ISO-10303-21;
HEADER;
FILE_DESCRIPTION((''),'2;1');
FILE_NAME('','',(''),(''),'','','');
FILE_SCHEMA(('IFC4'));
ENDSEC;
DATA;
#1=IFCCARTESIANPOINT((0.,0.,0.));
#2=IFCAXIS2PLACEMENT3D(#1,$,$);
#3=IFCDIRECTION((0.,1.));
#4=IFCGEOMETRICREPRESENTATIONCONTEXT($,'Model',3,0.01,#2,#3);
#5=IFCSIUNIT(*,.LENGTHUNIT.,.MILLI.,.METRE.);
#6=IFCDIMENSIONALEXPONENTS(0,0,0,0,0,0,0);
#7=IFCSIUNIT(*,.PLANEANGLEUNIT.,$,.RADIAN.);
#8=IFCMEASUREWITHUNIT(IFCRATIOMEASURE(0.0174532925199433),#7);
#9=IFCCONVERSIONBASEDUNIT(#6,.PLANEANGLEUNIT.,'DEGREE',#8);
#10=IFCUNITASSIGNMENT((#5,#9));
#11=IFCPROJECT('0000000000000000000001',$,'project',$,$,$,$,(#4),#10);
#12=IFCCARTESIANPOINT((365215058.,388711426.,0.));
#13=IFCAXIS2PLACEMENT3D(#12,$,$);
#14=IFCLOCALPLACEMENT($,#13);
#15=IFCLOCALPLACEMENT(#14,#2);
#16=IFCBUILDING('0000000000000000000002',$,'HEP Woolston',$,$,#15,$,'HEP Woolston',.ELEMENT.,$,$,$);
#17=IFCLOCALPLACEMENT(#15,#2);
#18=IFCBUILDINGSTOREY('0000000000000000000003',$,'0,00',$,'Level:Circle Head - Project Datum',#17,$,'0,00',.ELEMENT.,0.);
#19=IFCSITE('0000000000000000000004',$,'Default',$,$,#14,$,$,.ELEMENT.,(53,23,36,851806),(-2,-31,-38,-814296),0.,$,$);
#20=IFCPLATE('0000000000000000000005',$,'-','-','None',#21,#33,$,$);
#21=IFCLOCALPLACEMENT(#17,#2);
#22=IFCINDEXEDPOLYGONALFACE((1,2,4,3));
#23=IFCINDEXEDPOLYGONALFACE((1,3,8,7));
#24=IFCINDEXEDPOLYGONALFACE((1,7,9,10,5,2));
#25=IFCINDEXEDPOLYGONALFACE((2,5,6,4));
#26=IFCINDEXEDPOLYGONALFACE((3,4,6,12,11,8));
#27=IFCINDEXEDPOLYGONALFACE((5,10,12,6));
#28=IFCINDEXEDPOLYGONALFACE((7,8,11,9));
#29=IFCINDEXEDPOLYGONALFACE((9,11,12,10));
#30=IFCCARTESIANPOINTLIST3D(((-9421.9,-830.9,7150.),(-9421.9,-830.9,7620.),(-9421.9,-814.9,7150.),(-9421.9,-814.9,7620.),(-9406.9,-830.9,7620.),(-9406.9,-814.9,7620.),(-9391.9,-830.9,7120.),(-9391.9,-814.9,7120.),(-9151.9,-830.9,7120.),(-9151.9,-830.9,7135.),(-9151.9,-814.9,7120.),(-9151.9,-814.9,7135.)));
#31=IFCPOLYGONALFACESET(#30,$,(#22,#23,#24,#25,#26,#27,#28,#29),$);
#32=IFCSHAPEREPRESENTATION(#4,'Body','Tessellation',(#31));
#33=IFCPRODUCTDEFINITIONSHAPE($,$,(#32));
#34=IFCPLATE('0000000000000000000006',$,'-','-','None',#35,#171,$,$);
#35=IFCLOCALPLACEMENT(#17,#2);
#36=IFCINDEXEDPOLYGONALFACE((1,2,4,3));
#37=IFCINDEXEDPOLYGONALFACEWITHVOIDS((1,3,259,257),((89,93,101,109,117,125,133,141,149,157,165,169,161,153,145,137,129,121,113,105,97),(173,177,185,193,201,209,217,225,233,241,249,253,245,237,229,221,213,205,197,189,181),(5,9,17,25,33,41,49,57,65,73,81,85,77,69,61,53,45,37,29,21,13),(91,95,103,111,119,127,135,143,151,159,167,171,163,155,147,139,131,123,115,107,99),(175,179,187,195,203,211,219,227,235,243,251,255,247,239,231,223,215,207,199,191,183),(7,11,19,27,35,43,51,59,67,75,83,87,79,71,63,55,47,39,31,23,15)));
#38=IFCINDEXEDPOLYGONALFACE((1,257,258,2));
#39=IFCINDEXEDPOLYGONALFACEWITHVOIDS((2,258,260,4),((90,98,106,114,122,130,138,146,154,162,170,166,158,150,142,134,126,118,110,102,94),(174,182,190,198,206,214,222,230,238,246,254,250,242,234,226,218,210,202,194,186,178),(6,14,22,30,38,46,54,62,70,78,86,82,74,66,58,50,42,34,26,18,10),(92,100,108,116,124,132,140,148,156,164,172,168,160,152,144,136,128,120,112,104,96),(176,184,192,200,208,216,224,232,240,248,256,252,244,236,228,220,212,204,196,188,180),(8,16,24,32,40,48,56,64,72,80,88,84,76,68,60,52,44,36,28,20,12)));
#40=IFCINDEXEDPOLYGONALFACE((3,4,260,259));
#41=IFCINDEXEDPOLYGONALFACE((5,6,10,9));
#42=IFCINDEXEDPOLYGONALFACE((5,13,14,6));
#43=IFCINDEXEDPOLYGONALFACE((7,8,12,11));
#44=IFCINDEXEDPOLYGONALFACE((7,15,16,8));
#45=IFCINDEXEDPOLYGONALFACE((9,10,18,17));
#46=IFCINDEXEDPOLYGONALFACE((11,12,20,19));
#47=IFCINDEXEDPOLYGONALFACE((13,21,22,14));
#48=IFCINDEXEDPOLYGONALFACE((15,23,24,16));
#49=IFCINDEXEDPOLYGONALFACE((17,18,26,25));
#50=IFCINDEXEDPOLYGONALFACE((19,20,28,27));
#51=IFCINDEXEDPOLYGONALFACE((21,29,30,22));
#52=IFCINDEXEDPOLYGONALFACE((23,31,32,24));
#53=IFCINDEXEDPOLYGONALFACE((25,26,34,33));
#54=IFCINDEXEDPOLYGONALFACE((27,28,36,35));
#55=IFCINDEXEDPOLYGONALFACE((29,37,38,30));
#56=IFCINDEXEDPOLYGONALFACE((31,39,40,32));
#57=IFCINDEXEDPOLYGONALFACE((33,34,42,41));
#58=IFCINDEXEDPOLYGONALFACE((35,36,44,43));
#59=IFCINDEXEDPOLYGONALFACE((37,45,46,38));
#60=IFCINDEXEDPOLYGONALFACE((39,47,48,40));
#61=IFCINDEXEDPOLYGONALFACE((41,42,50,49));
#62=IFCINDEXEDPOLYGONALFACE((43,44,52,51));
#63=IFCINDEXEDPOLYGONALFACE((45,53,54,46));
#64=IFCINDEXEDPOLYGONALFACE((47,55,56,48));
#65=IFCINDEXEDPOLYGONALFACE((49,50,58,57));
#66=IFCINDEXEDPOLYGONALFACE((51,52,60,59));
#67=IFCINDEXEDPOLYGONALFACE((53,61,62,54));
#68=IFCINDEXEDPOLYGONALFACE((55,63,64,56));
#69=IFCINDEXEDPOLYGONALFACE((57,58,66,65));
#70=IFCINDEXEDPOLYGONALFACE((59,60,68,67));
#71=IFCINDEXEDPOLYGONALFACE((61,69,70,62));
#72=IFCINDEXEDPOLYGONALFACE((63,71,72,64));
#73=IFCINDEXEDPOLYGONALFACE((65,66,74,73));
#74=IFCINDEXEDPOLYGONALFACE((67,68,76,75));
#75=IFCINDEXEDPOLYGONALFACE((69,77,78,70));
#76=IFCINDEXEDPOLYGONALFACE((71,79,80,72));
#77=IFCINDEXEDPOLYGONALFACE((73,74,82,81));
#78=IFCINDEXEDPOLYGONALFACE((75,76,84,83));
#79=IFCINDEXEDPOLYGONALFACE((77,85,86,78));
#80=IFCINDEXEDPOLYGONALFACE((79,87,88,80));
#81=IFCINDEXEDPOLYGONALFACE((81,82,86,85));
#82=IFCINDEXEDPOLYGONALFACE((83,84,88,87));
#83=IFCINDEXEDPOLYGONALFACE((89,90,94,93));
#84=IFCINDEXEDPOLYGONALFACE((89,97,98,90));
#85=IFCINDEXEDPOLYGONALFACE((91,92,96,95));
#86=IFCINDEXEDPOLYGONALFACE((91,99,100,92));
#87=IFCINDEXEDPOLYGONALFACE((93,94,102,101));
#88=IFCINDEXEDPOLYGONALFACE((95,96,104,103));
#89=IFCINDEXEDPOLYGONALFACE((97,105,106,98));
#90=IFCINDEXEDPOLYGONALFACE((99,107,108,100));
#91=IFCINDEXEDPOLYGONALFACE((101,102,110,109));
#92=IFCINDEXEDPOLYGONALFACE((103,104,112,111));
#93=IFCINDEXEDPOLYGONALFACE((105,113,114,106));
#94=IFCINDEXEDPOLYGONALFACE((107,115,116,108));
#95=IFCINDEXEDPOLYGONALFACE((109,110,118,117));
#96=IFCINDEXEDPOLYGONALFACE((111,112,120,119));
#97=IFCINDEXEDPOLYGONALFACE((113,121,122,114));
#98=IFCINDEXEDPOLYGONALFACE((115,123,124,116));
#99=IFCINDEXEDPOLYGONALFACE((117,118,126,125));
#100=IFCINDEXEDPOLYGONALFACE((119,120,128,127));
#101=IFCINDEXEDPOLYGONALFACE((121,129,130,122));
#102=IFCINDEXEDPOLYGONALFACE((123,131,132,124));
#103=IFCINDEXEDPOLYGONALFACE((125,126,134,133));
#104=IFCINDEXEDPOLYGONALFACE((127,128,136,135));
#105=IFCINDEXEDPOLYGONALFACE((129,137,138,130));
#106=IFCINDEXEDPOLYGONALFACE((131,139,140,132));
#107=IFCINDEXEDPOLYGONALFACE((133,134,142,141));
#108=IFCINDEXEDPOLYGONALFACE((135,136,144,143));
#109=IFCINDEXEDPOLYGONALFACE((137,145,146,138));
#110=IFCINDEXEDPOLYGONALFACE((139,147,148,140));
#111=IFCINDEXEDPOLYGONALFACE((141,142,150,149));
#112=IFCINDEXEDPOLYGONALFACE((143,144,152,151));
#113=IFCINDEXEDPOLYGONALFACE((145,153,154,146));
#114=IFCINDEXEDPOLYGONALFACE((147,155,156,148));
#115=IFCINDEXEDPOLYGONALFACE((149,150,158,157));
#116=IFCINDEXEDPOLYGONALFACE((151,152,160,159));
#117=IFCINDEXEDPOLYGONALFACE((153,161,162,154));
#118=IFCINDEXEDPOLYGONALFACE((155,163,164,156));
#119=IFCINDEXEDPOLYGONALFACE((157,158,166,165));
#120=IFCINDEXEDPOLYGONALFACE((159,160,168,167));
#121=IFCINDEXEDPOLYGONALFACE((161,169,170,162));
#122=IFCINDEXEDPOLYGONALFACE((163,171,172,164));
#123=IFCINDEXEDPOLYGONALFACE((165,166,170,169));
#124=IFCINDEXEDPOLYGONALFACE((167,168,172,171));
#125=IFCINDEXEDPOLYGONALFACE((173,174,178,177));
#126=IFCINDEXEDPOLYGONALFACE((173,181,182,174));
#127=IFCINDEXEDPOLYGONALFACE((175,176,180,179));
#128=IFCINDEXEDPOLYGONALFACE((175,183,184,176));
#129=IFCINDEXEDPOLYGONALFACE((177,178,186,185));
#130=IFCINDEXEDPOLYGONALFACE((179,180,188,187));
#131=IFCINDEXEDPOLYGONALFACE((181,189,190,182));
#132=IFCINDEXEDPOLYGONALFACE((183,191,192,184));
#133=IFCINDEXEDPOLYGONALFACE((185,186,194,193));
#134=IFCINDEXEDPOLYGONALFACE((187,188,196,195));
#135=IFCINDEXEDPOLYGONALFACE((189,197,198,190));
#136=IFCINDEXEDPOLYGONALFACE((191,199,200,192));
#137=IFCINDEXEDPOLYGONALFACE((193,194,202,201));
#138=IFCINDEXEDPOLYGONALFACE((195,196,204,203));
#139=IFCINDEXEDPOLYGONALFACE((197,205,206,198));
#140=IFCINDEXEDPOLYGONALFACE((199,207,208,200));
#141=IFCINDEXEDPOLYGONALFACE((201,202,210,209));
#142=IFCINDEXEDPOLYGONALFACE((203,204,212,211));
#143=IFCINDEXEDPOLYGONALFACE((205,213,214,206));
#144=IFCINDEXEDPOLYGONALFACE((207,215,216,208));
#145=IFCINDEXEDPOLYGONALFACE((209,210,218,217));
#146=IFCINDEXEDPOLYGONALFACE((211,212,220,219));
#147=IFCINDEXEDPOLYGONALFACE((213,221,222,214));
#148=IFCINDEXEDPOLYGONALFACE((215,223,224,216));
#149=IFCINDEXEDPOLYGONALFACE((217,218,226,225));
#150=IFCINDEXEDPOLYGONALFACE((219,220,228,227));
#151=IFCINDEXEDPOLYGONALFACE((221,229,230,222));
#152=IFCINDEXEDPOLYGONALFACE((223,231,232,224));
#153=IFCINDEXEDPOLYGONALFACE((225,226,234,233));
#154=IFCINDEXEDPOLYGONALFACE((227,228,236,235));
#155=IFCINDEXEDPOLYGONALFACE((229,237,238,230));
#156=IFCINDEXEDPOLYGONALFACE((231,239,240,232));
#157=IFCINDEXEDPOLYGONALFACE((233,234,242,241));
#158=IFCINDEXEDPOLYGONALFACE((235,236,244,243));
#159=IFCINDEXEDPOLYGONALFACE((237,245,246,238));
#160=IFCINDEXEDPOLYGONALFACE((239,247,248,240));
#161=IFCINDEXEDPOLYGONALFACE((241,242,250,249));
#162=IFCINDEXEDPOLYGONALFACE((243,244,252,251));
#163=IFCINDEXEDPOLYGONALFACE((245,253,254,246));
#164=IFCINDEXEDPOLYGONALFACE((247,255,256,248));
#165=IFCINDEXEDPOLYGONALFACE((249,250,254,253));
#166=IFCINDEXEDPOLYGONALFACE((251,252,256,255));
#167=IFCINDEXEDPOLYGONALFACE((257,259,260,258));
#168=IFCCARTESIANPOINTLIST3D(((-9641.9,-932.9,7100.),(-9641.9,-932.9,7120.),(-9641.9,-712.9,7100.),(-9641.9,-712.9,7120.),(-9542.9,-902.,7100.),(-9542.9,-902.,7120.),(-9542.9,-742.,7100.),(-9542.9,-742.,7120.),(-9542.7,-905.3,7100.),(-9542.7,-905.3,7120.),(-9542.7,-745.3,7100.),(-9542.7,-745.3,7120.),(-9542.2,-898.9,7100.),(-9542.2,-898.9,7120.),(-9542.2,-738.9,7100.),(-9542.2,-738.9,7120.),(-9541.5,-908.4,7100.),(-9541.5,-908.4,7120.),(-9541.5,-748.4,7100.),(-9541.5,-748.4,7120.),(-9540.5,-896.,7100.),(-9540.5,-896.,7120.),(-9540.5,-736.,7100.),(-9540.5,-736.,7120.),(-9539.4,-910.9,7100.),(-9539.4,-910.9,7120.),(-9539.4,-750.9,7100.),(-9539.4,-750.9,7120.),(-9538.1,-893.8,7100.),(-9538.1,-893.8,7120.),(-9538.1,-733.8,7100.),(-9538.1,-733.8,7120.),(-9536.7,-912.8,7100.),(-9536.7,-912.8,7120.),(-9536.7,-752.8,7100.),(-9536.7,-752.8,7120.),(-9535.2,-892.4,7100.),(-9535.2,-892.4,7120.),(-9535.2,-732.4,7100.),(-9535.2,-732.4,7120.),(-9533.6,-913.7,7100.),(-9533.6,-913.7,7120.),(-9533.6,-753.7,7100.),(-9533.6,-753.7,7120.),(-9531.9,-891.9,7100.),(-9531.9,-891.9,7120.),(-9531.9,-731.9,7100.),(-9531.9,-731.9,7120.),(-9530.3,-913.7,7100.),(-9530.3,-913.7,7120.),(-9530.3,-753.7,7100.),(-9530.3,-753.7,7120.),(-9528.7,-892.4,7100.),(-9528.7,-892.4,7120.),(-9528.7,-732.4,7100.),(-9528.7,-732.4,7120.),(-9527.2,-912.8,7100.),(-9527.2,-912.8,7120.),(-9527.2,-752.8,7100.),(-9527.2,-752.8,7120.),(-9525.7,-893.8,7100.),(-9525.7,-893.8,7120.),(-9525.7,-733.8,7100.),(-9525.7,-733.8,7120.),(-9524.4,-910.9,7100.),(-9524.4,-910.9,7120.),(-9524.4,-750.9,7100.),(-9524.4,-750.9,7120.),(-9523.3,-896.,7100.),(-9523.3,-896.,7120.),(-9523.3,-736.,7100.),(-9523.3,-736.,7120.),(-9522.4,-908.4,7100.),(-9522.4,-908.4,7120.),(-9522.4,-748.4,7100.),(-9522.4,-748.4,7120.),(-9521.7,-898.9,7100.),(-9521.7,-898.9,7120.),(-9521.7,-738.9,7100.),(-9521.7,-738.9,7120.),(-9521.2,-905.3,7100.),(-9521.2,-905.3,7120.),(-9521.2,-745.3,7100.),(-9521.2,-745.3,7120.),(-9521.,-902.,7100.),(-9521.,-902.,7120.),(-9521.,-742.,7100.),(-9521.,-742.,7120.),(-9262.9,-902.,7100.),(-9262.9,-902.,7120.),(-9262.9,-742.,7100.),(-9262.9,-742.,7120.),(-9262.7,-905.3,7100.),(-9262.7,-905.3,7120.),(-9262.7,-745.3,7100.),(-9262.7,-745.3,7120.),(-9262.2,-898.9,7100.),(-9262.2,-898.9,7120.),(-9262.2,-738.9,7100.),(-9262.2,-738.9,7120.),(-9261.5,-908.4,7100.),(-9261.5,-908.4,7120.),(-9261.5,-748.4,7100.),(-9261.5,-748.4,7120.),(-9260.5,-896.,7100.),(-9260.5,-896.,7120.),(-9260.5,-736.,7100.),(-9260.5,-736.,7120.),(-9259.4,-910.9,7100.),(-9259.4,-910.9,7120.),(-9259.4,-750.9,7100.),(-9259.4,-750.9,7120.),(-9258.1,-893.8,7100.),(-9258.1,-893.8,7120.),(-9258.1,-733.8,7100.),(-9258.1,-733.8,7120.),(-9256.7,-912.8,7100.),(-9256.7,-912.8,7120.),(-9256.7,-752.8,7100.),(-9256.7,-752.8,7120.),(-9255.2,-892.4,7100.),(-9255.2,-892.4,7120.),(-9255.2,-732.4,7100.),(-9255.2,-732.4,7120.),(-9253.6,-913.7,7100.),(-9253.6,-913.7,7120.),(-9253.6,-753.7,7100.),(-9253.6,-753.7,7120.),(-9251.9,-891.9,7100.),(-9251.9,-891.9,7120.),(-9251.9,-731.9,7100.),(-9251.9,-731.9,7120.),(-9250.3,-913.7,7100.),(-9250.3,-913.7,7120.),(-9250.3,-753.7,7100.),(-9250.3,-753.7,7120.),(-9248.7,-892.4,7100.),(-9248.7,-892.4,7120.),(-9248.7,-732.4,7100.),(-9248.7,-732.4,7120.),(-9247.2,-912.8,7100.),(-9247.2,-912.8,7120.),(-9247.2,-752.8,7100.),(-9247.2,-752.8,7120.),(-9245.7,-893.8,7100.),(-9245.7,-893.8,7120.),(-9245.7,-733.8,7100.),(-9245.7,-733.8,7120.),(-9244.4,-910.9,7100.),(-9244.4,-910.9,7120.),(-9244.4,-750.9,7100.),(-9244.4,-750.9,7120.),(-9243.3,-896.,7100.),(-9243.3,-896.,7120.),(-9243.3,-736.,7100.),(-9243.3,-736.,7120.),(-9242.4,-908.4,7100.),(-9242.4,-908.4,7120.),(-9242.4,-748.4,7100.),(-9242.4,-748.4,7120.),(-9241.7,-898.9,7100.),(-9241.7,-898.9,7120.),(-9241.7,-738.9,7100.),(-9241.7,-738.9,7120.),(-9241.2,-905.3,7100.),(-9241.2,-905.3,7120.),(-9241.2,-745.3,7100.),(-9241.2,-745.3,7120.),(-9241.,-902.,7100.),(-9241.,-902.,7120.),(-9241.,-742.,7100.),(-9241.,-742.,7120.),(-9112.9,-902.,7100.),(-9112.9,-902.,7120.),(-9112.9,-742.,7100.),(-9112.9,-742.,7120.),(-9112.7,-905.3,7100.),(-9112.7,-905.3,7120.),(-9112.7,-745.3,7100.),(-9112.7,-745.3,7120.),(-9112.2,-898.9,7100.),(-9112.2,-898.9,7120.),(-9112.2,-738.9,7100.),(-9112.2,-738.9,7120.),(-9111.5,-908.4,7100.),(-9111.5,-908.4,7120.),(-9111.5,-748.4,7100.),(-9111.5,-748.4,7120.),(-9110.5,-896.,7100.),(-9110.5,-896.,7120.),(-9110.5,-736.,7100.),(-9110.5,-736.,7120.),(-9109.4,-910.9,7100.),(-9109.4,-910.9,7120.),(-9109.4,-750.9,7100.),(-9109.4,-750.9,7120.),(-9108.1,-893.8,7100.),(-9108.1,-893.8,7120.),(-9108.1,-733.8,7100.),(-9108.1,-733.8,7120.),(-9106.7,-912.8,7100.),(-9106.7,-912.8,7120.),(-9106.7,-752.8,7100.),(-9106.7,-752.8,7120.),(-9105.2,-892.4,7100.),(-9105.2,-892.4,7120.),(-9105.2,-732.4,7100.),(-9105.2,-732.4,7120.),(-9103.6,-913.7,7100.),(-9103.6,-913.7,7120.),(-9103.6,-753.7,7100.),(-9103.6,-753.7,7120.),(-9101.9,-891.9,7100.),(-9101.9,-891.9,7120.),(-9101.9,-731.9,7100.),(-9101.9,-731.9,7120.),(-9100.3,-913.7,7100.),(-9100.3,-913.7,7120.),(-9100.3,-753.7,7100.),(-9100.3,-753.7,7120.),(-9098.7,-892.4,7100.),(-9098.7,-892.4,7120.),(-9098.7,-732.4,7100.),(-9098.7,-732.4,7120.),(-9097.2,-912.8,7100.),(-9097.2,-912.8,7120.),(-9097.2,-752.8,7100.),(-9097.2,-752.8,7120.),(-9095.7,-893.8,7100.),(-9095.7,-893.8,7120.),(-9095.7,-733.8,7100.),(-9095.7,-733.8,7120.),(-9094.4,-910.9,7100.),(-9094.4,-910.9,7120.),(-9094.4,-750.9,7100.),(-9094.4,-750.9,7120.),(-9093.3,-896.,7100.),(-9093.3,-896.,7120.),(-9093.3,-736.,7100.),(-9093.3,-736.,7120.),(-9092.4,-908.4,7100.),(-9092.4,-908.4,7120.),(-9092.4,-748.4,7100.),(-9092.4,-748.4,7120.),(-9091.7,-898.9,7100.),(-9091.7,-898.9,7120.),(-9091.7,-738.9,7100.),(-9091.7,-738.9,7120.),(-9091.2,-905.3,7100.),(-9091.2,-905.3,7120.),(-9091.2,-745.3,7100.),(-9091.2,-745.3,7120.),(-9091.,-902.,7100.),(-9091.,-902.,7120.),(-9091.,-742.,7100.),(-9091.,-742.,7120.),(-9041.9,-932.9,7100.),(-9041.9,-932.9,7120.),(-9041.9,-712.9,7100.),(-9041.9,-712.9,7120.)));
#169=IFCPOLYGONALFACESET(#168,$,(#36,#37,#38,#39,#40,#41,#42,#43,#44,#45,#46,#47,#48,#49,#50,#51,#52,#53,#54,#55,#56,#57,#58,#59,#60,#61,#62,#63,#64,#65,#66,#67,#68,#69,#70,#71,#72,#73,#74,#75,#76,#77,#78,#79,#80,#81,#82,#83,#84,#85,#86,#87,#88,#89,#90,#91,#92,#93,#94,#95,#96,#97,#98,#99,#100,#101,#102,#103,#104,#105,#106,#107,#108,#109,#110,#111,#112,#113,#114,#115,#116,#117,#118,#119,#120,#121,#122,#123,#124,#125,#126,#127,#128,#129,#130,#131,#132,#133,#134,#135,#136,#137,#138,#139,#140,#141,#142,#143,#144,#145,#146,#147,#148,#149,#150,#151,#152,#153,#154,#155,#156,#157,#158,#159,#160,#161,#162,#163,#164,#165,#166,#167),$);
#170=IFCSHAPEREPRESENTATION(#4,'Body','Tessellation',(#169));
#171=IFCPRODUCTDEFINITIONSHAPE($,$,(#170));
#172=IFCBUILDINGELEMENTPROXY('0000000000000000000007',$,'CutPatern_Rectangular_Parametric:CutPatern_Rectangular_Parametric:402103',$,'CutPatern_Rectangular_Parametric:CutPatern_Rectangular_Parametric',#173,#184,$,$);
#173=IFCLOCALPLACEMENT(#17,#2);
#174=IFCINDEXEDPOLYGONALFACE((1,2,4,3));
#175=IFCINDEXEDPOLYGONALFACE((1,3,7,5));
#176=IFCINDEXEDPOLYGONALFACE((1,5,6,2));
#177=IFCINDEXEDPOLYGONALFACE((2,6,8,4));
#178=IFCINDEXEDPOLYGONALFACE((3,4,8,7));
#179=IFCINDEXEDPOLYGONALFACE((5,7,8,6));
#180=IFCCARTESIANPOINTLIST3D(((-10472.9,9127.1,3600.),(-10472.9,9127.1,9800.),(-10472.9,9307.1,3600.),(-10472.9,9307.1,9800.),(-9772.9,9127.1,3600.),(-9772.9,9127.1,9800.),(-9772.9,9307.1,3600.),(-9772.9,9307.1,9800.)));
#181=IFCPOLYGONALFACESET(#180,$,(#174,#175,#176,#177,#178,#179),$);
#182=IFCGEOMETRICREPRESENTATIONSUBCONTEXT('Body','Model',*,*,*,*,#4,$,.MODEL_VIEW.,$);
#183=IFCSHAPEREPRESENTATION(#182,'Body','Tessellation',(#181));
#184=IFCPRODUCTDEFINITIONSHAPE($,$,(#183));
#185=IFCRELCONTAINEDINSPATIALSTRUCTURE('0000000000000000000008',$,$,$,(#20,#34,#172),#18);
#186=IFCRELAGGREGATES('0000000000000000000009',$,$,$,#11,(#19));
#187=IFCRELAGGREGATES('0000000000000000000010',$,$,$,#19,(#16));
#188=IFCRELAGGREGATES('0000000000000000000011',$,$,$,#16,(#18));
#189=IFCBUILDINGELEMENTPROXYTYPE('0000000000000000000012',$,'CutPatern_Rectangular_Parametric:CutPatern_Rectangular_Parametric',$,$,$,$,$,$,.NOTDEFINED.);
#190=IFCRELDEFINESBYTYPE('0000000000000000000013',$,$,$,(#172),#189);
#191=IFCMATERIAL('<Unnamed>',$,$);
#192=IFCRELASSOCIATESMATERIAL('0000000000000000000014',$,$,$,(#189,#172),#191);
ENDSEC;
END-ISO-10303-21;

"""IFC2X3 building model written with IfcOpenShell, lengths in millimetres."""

from ifc_helpers import new_model, entity, si_unit, converted_unit, direction, frame, frame_2d, origin, origin_with_axes, place, context, subcontext, project, spatial, polyline, rectangle, circle, outline, extrude, source, transform, mapped, material, type_object, type_shapes, element, save


model = new_model("IFC2X3")

# Units and contexts
model_context = context("Model", 3, precision=0.01, world=origin(), true_north=direction((0.0, 1.0)))
body_context = subcontext(model_context, "Body", "Model", "MODEL_VIEW")
ifc_project = project(units=[si_unit("LENGTHUNIT", "METRE", prefix="MILLI"), converted_unit("PLANEANGLEUNIT", "DEGREE", entity("IfcRatioMeasure", 0.0174532925199433), si_unit("PLANEANGLEUNIT", "RADIAN"), dimensions=[0, 0, 0, 0, 0, 0, 0])], contexts=[model_context])

# Site, building, storey
site_placement = place(None, frame((365215058.0, 388711426.0, 0.0)))
site = spatial("IfcSite", under=ifc_project, at=site_placement, Name="Default", CompositionType="ELEMENT", RefLatitude=(53, 23, 36, 851806), RefLongitude=(-2, -31, -38, -814296), RefElevation=0.0)
building_placement = place(site_placement, origin())
building = spatial("IfcBuilding", under=site, at=building_placement, Name="HEP Woolston", LongName="HEP Woolston", CompositionType="ELEMENT")
storey_placement = place(building_placement, origin())
storey = spatial("IfcBuildingStorey", under=building, at=storey_placement, Name="0,00", ObjectType="Level:Circle Head - Project Datum", LongName="0,00", CompositionType="ELEMENT", Elevation=0.0)

# Plate
plate_1_placement = place(storey_placement, frame((-9421.9, -814.9, 7620.0), z_axis=(0.0, -1.0, 0.0), x_axis=(1.0, 0.0, 0.0)))
element("IfcPlate", 1, at=plate_1_placement, inside=storey, Name="-", Description="-", ObjectType="None", context=model_context, shape_type="SweptSolid", body=[
    extrude(outline(polyline([(0.0, -470.0), (30.0, -500.0), (270.0, -500.0), (270.0, -485.0), (15.0, 0.0), (0.0, 0.0), (0.0, -470.0)])), origin_with_axes(), (0.0, 0.0, 1.0), 16.0),
])

# Plate, openings
plate_2_placement = place(storey_placement, frame((-9041.9, -712.9, 7100.0)))
plate_2 = element("IfcPlate", 2, at=plate_2_placement, inside=storey, Name="-", Description="-", ObjectType="None", context=model_context, shape_type="SweptSolid", body=[
    extrude(outline(polyline([(0.0, 0.0), (-600.0, 0.0), (-600.0, -220.0), (0.0, -220.0), (0.0, 0.0)])), origin_with_axes(), (0.0, 0.0, 1.0), 20.0),
])
opening_1_placement = place(plate_2_placement, frame((-490.0, -110.0, -0.5), z_axis=(0.0, 0.0, 1.0), x_axis=(0.0, 1.0, 0.0)))
element("IfcOpeningElement", 3, at=opening_1_placement, cuts=plate_2, ObjectType="Opening", context=model_context, shape_type="SweptSolid", body=[
    extrude(circle(Radius=11.0, at=frame_2d((80.0, 0.0), x_axis=(1.0, 0.0))), origin(), (0.0, 0.0, 1.0), 21.0),
])
opening_2_placement = place(plate_2_placement, frame((-490.0, -110.0, -0.5), z_axis=(0.0, 0.0, 1.0), x_axis=(0.0, 1.0, 0.0)))
element("IfcOpeningElement", 4, at=opening_2_placement, cuts=plate_2, ObjectType="Opening", context=model_context, shape_type="SweptSolid", body=[
    extrude(circle(Radius=11.0, at=frame_2d((-80.0, 0.0), x_axis=(1.0, 0.0))), origin(), (0.0, 0.0, 1.0), 21.0),
])
opening_3_placement = place(plate_2_placement, frame((-135.0, -110.0, -0.5), z_axis=(0.0, 0.0, 1.0), x_axis=(0.0, 1.0, 0.0)))
element("IfcOpeningElement", 5, at=opening_3_placement, cuts=plate_2, ObjectType="Opening", context=model_context, shape_type="SweptSolid", body=[
    extrude(circle(Radius=11.0, at=frame_2d((80.0, 75.0), x_axis=(1.0, 0.0))), origin(), (0.0, 0.0, 1.0), 21.0),
])
opening_4_placement = place(plate_2_placement, frame((-135.0, -110.0, -0.5), z_axis=(0.0, 0.0, 1.0), x_axis=(0.0, 1.0, 0.0)))
element("IfcOpeningElement", 6, at=opening_4_placement, cuts=plate_2, ObjectType="Opening", context=model_context, shape_type="SweptSolid", body=[
    extrude(circle(Radius=11.0, at=frame_2d((-80.0, 75.0), x_axis=(1.0, 0.0))), origin(), (0.0, 0.0, 1.0), 21.0),
])
opening_5_placement = place(plate_2_placement, frame((-135.0, -110.0, -0.5), z_axis=(0.0, 0.0, 1.0), x_axis=(0.0, 1.0, 0.0)))
element("IfcOpeningElement", 7, at=opening_5_placement, cuts=plate_2, ObjectType="Opening", context=model_context, shape_type="SweptSolid", body=[
    extrude(circle(Radius=11.0, at=frame_2d((80.0, -75.0), x_axis=(1.0, 0.0))), origin(), (0.0, 0.0, 1.0), 21.0),
])
opening_6_placement = place(plate_2_placement, frame((-135.0, -110.0, -0.5), z_axis=(0.0, 0.0, 1.0), x_axis=(0.0, 1.0, 0.0)))
element("IfcOpeningElement", 8, at=opening_6_placement, cuts=plate_2, ObjectType="Opening", context=model_context, shape_type="SweptSolid", body=[
    extrude(circle(Radius=11.0, at=frame_2d((-80.0, -75.0), x_axis=(1.0, 0.0))), origin(), (0.0, 0.0, 1.0), 21.0),
])

# Building element proxy
ifc_material_1 = material(Name="<Unnamed>")
building_element_proxy_type_1 = type_object("IfcBuildingElementProxyType", Name="CutPatern_Rectangular_Parametric:CutPatern_Rectangular_Parametric", PredefinedType="NOTDEFINED", material=ifc_material_1)
shared_shape_1 = source(origin(), body_context, "Body", "SweptSolid", [
    extrude(rectangle(XDim=180.0, YDim=700.0, at=frame_2d((0.0, 0.0), x_axis=(1.0, 0.0))), frame((-10122.9, 9217.1, 3600.0), z_axis=(0.0, 0.0, 1.0), x_axis=(0.0, -1.0, 0.0)), (0.0, 0.0, 1.0), 6200.0),
])
type_shapes(building_element_proxy_type_1, [shared_shape_1])
proxy_1_placement = place(storey_placement, origin())
element("IfcBuildingElementProxy", 9, at=proxy_1_placement, inside=storey, type_object=building_element_proxy_type_1, material=ifc_material_1, Name="CutPatern_Rectangular_Parametric:CutPatern_Rectangular_Parametric:402103", ObjectType="CutPatern_Rectangular_Parametric:CutPatern_Rectangular_Parametric", context=body_context, shape_type="MappedRepresentation", body=[
    mapped(shared_shape_1, transform((0.0, 0.0, 0.0), scale=1.0)),
])

save(model, "model.ifc")
